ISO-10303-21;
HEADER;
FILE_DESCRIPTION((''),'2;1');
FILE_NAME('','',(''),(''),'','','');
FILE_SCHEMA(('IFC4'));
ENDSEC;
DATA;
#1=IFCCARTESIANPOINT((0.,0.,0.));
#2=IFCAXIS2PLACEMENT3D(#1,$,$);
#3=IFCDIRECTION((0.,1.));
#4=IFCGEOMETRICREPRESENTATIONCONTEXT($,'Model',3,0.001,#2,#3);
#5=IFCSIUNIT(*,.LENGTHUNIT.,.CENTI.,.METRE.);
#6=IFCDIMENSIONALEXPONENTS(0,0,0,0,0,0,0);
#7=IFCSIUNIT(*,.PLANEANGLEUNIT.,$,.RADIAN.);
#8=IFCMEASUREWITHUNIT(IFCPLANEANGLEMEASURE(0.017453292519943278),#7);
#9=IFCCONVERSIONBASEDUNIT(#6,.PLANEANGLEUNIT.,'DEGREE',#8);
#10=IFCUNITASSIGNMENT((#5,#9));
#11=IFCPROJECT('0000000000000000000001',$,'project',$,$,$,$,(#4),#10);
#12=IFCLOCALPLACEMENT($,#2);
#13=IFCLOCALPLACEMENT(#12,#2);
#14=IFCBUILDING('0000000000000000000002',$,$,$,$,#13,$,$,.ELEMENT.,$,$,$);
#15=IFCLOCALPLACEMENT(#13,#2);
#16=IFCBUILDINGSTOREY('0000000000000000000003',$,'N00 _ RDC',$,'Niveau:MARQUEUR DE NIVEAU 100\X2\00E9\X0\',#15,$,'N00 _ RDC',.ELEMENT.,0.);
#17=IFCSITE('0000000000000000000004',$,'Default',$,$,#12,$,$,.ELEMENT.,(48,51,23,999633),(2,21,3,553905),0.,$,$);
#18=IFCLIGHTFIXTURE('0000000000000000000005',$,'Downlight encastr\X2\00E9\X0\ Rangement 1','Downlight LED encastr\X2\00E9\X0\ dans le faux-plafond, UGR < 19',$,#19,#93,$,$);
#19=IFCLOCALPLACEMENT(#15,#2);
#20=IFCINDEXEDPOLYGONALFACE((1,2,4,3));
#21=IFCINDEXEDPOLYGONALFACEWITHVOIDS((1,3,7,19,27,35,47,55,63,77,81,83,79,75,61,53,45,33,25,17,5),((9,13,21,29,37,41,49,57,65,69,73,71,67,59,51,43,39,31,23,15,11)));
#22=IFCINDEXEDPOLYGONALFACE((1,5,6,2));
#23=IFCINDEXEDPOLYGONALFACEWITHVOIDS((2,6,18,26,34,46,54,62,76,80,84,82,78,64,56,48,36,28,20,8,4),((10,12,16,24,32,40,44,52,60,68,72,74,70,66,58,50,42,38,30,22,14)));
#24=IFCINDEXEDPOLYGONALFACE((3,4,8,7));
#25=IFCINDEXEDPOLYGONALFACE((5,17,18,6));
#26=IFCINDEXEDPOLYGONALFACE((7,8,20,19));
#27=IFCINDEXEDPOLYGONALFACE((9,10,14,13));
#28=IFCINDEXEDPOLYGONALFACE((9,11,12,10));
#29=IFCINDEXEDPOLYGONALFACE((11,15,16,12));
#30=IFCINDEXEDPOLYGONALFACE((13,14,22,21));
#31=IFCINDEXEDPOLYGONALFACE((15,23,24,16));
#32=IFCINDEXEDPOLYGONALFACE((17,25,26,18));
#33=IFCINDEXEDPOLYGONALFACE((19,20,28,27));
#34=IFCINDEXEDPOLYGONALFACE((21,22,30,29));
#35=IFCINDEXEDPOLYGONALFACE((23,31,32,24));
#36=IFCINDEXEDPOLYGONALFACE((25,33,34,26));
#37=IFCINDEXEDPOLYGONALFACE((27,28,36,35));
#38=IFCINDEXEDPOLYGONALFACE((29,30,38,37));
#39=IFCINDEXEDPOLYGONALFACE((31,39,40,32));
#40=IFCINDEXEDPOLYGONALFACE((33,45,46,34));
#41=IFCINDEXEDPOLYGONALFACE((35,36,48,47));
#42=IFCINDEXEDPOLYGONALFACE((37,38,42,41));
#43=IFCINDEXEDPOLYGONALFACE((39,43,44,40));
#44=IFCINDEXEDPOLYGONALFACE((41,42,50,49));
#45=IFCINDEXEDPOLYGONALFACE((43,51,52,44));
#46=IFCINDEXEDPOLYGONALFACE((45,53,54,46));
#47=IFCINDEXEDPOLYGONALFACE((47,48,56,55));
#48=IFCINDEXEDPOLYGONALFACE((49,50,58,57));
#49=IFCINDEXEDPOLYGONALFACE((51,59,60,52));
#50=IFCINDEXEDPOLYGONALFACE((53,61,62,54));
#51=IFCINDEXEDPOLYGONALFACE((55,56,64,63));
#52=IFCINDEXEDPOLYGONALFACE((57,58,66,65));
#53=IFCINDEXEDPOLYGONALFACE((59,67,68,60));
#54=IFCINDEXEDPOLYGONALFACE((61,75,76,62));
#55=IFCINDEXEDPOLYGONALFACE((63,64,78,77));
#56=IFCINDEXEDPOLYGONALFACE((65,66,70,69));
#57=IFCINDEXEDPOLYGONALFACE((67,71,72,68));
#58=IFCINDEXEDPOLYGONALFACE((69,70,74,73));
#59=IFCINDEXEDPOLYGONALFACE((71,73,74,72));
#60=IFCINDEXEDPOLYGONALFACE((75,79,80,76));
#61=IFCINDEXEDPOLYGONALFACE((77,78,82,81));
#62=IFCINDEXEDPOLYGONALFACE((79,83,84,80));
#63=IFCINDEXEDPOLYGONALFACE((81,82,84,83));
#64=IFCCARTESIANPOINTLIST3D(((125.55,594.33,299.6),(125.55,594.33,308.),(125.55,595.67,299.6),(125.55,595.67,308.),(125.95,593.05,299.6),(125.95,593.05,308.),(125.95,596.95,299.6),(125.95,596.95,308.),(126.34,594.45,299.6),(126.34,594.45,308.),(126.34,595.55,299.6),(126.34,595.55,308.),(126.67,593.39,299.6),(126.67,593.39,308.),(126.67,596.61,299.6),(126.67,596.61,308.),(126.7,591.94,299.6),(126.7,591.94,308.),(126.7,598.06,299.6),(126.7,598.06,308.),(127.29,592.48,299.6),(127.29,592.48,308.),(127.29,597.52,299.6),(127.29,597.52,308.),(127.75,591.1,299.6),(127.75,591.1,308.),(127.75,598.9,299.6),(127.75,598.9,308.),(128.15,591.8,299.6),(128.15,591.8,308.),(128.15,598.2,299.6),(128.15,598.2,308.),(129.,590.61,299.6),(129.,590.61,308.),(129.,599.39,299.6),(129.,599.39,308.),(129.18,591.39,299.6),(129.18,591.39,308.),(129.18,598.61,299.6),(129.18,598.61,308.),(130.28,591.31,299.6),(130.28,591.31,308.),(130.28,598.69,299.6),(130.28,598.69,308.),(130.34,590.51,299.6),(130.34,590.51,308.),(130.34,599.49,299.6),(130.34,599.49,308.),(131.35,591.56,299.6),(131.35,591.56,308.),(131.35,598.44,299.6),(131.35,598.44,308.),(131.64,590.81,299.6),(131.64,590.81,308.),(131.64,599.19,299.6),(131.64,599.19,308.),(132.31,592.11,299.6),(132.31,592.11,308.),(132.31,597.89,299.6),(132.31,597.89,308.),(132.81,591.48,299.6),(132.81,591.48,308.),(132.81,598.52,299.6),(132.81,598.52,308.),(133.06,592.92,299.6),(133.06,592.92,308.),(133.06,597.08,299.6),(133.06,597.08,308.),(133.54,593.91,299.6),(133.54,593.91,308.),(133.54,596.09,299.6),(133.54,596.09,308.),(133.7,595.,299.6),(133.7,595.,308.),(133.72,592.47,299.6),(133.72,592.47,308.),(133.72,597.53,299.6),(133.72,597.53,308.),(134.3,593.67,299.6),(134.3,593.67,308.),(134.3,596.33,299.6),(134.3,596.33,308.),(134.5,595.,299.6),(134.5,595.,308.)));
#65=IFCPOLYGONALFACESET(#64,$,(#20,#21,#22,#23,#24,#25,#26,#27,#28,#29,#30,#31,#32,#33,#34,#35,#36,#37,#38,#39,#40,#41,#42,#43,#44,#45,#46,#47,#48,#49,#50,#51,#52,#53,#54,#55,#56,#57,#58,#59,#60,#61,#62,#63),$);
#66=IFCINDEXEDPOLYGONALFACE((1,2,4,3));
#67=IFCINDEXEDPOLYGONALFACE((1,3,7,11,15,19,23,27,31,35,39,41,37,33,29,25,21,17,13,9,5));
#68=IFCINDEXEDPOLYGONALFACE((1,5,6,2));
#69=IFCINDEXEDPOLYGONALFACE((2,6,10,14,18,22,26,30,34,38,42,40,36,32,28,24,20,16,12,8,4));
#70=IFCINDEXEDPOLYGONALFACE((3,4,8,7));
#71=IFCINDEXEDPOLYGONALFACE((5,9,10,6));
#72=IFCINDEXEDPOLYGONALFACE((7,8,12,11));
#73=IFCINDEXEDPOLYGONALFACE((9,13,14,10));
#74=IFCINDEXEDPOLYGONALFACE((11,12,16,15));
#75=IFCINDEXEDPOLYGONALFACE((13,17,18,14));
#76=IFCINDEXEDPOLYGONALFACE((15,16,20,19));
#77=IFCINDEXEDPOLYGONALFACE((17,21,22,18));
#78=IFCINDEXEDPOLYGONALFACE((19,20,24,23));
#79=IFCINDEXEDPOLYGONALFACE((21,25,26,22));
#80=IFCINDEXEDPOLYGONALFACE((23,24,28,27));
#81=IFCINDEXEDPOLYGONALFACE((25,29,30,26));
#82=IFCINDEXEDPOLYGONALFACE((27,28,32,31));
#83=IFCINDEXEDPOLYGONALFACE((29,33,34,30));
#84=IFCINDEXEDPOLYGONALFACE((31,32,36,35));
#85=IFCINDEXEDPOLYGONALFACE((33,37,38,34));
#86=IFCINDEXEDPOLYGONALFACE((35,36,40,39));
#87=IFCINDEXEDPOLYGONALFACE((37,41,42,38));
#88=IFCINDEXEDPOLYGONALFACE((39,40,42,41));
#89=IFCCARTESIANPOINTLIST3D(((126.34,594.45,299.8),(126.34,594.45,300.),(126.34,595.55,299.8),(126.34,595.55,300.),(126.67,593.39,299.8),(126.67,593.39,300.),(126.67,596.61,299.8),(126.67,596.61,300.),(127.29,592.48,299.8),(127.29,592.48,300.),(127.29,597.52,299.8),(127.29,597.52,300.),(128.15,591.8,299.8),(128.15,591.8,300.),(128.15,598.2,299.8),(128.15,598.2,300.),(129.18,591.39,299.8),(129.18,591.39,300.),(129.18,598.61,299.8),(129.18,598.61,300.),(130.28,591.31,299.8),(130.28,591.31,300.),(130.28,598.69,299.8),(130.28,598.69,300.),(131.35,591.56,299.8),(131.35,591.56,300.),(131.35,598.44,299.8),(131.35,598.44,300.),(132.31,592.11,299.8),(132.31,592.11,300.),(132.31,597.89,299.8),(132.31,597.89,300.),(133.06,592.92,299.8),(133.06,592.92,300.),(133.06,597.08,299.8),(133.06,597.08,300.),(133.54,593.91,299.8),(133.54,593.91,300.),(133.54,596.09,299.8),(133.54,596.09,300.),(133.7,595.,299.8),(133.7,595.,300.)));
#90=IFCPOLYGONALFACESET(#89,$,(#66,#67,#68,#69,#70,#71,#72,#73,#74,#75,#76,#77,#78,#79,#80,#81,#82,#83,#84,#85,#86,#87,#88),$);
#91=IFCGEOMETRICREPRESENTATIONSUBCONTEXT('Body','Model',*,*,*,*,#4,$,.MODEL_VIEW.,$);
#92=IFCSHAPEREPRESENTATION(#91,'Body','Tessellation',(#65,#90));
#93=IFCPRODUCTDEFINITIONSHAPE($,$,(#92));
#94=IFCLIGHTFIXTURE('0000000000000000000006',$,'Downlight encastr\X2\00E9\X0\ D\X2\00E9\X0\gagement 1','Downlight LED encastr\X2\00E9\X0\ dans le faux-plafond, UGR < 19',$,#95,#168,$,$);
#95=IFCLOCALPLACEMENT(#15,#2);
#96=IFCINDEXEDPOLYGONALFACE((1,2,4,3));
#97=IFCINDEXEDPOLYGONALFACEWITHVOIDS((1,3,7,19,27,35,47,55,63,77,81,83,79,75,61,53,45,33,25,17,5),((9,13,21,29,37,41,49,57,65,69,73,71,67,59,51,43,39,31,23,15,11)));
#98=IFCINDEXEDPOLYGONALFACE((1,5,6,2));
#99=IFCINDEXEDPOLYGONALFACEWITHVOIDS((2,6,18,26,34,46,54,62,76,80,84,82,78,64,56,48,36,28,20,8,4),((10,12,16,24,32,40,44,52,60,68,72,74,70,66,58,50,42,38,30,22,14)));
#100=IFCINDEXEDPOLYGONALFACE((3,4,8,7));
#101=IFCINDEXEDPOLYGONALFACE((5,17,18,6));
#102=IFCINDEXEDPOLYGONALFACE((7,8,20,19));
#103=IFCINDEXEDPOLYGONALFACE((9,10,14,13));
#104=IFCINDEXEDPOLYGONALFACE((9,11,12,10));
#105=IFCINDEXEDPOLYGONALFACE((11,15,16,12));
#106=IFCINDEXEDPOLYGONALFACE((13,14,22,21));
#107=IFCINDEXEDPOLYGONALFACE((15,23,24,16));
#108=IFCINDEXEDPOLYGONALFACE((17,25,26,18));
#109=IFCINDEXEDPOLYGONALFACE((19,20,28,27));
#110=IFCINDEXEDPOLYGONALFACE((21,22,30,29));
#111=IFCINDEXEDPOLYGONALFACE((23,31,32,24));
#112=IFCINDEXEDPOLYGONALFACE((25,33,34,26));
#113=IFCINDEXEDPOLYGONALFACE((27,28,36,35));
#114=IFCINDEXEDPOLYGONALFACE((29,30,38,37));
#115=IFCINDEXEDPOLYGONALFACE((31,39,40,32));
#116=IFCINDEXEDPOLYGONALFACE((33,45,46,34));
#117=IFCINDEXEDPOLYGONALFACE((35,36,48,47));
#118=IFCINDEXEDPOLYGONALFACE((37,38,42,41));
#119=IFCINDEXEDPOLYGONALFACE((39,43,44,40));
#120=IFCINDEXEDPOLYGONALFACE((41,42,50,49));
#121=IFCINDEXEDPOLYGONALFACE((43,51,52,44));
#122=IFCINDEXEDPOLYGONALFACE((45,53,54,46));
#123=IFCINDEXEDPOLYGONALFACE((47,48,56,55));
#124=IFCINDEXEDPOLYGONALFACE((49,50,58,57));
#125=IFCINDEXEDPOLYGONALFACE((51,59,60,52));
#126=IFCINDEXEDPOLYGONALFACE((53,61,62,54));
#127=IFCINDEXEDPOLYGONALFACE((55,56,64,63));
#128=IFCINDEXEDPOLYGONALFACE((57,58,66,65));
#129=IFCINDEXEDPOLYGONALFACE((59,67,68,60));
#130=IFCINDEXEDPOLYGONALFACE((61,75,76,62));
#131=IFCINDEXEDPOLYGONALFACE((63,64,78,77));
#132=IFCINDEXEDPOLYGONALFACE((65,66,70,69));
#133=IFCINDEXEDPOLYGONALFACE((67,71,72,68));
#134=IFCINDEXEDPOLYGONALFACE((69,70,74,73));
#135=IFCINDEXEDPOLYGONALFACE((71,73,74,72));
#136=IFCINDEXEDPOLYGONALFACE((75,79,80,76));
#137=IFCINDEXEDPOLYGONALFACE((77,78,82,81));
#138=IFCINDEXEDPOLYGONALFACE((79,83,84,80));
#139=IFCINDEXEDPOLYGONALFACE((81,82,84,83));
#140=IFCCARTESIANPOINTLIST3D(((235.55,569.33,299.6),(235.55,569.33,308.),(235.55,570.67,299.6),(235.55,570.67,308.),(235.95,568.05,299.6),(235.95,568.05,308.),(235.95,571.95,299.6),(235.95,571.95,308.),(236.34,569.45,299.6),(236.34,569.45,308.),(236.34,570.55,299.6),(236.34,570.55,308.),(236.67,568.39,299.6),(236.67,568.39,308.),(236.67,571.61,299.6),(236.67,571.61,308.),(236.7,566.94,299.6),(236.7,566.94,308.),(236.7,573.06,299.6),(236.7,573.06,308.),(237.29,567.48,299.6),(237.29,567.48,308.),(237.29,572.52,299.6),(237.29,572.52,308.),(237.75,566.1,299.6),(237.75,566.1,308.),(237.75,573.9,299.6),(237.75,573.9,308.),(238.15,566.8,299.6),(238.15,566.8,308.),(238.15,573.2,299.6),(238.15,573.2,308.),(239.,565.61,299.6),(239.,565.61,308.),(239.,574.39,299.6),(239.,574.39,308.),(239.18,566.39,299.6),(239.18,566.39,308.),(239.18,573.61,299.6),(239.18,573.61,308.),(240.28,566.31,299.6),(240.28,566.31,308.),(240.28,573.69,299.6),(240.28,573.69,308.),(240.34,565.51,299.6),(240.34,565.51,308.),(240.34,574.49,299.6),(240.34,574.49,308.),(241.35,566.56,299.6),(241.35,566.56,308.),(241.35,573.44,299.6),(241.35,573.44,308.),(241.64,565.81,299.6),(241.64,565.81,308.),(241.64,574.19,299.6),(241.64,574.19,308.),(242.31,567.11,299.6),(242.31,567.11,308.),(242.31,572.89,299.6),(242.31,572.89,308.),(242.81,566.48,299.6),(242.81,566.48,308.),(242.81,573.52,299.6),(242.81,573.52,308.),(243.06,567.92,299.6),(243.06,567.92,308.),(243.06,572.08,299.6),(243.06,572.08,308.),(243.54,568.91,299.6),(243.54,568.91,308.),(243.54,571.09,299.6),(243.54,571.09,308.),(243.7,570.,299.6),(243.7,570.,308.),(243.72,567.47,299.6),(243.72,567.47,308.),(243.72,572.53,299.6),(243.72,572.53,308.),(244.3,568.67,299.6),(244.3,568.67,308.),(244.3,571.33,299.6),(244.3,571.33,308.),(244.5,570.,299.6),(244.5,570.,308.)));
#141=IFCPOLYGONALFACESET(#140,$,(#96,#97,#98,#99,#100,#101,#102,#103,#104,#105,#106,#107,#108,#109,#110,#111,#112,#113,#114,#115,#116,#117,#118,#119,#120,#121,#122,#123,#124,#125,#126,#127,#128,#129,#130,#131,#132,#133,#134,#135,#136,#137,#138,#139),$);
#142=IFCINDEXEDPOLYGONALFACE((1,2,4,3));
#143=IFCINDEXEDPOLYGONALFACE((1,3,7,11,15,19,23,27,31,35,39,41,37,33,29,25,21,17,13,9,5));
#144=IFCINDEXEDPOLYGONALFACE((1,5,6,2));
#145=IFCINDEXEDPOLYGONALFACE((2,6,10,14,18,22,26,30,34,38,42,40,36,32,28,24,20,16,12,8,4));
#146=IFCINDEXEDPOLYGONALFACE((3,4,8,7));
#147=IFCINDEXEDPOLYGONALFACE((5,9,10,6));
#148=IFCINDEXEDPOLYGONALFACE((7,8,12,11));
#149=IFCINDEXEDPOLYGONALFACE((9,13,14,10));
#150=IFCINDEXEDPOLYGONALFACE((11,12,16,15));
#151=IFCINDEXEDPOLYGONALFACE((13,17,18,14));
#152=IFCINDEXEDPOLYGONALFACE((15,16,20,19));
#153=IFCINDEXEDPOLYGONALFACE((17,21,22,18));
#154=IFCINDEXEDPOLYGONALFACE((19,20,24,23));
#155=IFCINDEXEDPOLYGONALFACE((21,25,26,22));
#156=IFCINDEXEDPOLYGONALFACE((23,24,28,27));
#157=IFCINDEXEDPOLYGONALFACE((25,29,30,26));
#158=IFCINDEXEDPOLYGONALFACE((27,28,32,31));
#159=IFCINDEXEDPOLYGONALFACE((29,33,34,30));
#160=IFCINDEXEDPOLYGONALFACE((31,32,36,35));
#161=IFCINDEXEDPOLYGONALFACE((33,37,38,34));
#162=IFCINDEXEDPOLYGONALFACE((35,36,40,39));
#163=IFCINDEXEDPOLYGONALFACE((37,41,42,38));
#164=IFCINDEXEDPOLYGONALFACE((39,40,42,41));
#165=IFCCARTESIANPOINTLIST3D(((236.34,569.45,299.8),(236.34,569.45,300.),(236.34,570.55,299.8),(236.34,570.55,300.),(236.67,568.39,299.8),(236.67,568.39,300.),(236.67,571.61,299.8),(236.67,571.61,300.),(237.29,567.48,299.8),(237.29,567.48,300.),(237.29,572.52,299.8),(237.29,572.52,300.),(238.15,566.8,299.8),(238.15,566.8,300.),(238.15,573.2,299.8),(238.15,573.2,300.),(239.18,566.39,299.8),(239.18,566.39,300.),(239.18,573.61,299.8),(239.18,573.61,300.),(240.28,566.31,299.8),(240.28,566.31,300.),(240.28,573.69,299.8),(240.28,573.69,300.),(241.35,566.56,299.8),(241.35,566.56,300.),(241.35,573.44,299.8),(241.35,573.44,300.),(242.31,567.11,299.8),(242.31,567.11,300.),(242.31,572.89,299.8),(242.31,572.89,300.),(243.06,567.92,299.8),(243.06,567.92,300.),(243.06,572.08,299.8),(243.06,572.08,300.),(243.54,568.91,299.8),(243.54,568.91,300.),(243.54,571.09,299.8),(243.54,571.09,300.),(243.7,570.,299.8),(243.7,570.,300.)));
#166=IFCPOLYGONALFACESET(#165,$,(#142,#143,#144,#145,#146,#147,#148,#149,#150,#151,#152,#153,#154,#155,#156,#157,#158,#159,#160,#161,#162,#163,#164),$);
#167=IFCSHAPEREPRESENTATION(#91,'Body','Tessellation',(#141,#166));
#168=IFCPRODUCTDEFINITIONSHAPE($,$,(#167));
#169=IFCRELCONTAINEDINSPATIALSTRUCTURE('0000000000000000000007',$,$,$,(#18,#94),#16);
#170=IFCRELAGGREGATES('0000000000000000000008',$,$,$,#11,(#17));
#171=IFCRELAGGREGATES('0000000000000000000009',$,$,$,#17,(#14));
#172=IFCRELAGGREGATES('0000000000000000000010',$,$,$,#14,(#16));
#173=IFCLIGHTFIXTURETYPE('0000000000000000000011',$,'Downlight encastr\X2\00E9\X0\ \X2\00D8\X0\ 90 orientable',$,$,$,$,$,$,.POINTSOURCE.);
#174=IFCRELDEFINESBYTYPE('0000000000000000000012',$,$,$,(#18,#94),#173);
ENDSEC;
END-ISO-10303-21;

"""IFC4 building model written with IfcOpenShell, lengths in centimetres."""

from ifc_helpers import new_model, entity, si_unit, converted_unit, direction, frame, frame_2d, origin, origin_with_axes, place, context, subcontext, project, spatial, circle, hollow_circle, extrude, type_object, element, save


model = new_model("IFC4")

# Units and contexts
model_context = context("Model", 3, precision=0.001, world=origin(), true_north=direction((0.0, 1.0)))
body_context = subcontext(model_context, "Body", "Model", "MODEL_VIEW")
ifc_project = project(units=[si_unit("LENGTHUNIT", "METRE", prefix="CENTI"), converted_unit("PLANEANGLEUNIT", "DEGREE", entity("IfcPlaneAngleMeasure", 0.017453292519943278), si_unit("PLANEANGLEUNIT", "RADIAN"), dimensions=[0, 0, 0, 0, 0, 0, 0])], contexts=[model_context])

# Site, building, storey
site_placement = place(None, origin())
site = spatial("IfcSite", under=ifc_project, at=site_placement, Name="Default", CompositionType="ELEMENT", RefLatitude=(48, 51, 23, 999633), RefLongitude=(2, 21, 3, 553905), RefElevation=0.0)
building_placement = place(site_placement, origin())
building = spatial("IfcBuilding", under=site, at=building_placement, CompositionType="ELEMENT")
storey_placement = place(building_placement, origin())
storey = spatial("IfcBuildingStorey", under=building, at=storey_placement, Name="N00 _ RDC", ObjectType="Niveau:MARQUEUR DE NIVEAU 100é", LongName="N00 _ RDC", CompositionType="ELEMENT", Elevation=0.0)

# Light fixtures
light_fixture_type_1 = type_object("IfcLightFixtureType", Name="Downlight encastré Ø 90 orientable", PredefinedType="POINTSOURCE")
light_fixture_1_placement = place(storey_placement, origin_with_axes())
element("IfcLightFixture", 1, at=light_fixture_1_placement, inside=storey, type_object=light_fixture_type_1, Name="Downlight encastré Rangement 1", Description="Downlight LED encastré dans le faux-plafond, UGR < 19", context=body_context, shape_type="SweptSolid", body=[
    extrude(hollow_circle(Radius=4.5, WallThickness=0.8, at=frame_2d((130.0, 595.0))), frame((0.0, 0.0, 299.6)), (0.0, 0.0, 1.0), 8.4),
    extrude(circle(Radius=3.7, at=frame_2d((130.0, 595.0))), frame((0.0, 0.0, 299.8)), (0.0, 0.0, 1.0), 0.2),
])
light_fixture_2_placement = place(storey_placement, origin_with_axes())
element("IfcLightFixture", 2, at=light_fixture_2_placement, inside=storey, type_object=light_fixture_type_1, Name="Downlight encastré Dégagement 1", Description="Downlight LED encastré dans le faux-plafond, UGR < 19", context=body_context, shape_type="SweptSolid", body=[
    extrude(hollow_circle(Radius=4.5, WallThickness=0.8, at=frame_2d((240.0, 570.0))), frame((0.0, 0.0, 299.6)), (0.0, 0.0, 1.0), 8.4),
    extrude(circle(Radius=3.7, at=frame_2d((240.0, 570.0))), frame((0.0, 0.0, 299.8)), (0.0, 0.0, 1.0), 0.2),
])

save(model, "model.ifc")
